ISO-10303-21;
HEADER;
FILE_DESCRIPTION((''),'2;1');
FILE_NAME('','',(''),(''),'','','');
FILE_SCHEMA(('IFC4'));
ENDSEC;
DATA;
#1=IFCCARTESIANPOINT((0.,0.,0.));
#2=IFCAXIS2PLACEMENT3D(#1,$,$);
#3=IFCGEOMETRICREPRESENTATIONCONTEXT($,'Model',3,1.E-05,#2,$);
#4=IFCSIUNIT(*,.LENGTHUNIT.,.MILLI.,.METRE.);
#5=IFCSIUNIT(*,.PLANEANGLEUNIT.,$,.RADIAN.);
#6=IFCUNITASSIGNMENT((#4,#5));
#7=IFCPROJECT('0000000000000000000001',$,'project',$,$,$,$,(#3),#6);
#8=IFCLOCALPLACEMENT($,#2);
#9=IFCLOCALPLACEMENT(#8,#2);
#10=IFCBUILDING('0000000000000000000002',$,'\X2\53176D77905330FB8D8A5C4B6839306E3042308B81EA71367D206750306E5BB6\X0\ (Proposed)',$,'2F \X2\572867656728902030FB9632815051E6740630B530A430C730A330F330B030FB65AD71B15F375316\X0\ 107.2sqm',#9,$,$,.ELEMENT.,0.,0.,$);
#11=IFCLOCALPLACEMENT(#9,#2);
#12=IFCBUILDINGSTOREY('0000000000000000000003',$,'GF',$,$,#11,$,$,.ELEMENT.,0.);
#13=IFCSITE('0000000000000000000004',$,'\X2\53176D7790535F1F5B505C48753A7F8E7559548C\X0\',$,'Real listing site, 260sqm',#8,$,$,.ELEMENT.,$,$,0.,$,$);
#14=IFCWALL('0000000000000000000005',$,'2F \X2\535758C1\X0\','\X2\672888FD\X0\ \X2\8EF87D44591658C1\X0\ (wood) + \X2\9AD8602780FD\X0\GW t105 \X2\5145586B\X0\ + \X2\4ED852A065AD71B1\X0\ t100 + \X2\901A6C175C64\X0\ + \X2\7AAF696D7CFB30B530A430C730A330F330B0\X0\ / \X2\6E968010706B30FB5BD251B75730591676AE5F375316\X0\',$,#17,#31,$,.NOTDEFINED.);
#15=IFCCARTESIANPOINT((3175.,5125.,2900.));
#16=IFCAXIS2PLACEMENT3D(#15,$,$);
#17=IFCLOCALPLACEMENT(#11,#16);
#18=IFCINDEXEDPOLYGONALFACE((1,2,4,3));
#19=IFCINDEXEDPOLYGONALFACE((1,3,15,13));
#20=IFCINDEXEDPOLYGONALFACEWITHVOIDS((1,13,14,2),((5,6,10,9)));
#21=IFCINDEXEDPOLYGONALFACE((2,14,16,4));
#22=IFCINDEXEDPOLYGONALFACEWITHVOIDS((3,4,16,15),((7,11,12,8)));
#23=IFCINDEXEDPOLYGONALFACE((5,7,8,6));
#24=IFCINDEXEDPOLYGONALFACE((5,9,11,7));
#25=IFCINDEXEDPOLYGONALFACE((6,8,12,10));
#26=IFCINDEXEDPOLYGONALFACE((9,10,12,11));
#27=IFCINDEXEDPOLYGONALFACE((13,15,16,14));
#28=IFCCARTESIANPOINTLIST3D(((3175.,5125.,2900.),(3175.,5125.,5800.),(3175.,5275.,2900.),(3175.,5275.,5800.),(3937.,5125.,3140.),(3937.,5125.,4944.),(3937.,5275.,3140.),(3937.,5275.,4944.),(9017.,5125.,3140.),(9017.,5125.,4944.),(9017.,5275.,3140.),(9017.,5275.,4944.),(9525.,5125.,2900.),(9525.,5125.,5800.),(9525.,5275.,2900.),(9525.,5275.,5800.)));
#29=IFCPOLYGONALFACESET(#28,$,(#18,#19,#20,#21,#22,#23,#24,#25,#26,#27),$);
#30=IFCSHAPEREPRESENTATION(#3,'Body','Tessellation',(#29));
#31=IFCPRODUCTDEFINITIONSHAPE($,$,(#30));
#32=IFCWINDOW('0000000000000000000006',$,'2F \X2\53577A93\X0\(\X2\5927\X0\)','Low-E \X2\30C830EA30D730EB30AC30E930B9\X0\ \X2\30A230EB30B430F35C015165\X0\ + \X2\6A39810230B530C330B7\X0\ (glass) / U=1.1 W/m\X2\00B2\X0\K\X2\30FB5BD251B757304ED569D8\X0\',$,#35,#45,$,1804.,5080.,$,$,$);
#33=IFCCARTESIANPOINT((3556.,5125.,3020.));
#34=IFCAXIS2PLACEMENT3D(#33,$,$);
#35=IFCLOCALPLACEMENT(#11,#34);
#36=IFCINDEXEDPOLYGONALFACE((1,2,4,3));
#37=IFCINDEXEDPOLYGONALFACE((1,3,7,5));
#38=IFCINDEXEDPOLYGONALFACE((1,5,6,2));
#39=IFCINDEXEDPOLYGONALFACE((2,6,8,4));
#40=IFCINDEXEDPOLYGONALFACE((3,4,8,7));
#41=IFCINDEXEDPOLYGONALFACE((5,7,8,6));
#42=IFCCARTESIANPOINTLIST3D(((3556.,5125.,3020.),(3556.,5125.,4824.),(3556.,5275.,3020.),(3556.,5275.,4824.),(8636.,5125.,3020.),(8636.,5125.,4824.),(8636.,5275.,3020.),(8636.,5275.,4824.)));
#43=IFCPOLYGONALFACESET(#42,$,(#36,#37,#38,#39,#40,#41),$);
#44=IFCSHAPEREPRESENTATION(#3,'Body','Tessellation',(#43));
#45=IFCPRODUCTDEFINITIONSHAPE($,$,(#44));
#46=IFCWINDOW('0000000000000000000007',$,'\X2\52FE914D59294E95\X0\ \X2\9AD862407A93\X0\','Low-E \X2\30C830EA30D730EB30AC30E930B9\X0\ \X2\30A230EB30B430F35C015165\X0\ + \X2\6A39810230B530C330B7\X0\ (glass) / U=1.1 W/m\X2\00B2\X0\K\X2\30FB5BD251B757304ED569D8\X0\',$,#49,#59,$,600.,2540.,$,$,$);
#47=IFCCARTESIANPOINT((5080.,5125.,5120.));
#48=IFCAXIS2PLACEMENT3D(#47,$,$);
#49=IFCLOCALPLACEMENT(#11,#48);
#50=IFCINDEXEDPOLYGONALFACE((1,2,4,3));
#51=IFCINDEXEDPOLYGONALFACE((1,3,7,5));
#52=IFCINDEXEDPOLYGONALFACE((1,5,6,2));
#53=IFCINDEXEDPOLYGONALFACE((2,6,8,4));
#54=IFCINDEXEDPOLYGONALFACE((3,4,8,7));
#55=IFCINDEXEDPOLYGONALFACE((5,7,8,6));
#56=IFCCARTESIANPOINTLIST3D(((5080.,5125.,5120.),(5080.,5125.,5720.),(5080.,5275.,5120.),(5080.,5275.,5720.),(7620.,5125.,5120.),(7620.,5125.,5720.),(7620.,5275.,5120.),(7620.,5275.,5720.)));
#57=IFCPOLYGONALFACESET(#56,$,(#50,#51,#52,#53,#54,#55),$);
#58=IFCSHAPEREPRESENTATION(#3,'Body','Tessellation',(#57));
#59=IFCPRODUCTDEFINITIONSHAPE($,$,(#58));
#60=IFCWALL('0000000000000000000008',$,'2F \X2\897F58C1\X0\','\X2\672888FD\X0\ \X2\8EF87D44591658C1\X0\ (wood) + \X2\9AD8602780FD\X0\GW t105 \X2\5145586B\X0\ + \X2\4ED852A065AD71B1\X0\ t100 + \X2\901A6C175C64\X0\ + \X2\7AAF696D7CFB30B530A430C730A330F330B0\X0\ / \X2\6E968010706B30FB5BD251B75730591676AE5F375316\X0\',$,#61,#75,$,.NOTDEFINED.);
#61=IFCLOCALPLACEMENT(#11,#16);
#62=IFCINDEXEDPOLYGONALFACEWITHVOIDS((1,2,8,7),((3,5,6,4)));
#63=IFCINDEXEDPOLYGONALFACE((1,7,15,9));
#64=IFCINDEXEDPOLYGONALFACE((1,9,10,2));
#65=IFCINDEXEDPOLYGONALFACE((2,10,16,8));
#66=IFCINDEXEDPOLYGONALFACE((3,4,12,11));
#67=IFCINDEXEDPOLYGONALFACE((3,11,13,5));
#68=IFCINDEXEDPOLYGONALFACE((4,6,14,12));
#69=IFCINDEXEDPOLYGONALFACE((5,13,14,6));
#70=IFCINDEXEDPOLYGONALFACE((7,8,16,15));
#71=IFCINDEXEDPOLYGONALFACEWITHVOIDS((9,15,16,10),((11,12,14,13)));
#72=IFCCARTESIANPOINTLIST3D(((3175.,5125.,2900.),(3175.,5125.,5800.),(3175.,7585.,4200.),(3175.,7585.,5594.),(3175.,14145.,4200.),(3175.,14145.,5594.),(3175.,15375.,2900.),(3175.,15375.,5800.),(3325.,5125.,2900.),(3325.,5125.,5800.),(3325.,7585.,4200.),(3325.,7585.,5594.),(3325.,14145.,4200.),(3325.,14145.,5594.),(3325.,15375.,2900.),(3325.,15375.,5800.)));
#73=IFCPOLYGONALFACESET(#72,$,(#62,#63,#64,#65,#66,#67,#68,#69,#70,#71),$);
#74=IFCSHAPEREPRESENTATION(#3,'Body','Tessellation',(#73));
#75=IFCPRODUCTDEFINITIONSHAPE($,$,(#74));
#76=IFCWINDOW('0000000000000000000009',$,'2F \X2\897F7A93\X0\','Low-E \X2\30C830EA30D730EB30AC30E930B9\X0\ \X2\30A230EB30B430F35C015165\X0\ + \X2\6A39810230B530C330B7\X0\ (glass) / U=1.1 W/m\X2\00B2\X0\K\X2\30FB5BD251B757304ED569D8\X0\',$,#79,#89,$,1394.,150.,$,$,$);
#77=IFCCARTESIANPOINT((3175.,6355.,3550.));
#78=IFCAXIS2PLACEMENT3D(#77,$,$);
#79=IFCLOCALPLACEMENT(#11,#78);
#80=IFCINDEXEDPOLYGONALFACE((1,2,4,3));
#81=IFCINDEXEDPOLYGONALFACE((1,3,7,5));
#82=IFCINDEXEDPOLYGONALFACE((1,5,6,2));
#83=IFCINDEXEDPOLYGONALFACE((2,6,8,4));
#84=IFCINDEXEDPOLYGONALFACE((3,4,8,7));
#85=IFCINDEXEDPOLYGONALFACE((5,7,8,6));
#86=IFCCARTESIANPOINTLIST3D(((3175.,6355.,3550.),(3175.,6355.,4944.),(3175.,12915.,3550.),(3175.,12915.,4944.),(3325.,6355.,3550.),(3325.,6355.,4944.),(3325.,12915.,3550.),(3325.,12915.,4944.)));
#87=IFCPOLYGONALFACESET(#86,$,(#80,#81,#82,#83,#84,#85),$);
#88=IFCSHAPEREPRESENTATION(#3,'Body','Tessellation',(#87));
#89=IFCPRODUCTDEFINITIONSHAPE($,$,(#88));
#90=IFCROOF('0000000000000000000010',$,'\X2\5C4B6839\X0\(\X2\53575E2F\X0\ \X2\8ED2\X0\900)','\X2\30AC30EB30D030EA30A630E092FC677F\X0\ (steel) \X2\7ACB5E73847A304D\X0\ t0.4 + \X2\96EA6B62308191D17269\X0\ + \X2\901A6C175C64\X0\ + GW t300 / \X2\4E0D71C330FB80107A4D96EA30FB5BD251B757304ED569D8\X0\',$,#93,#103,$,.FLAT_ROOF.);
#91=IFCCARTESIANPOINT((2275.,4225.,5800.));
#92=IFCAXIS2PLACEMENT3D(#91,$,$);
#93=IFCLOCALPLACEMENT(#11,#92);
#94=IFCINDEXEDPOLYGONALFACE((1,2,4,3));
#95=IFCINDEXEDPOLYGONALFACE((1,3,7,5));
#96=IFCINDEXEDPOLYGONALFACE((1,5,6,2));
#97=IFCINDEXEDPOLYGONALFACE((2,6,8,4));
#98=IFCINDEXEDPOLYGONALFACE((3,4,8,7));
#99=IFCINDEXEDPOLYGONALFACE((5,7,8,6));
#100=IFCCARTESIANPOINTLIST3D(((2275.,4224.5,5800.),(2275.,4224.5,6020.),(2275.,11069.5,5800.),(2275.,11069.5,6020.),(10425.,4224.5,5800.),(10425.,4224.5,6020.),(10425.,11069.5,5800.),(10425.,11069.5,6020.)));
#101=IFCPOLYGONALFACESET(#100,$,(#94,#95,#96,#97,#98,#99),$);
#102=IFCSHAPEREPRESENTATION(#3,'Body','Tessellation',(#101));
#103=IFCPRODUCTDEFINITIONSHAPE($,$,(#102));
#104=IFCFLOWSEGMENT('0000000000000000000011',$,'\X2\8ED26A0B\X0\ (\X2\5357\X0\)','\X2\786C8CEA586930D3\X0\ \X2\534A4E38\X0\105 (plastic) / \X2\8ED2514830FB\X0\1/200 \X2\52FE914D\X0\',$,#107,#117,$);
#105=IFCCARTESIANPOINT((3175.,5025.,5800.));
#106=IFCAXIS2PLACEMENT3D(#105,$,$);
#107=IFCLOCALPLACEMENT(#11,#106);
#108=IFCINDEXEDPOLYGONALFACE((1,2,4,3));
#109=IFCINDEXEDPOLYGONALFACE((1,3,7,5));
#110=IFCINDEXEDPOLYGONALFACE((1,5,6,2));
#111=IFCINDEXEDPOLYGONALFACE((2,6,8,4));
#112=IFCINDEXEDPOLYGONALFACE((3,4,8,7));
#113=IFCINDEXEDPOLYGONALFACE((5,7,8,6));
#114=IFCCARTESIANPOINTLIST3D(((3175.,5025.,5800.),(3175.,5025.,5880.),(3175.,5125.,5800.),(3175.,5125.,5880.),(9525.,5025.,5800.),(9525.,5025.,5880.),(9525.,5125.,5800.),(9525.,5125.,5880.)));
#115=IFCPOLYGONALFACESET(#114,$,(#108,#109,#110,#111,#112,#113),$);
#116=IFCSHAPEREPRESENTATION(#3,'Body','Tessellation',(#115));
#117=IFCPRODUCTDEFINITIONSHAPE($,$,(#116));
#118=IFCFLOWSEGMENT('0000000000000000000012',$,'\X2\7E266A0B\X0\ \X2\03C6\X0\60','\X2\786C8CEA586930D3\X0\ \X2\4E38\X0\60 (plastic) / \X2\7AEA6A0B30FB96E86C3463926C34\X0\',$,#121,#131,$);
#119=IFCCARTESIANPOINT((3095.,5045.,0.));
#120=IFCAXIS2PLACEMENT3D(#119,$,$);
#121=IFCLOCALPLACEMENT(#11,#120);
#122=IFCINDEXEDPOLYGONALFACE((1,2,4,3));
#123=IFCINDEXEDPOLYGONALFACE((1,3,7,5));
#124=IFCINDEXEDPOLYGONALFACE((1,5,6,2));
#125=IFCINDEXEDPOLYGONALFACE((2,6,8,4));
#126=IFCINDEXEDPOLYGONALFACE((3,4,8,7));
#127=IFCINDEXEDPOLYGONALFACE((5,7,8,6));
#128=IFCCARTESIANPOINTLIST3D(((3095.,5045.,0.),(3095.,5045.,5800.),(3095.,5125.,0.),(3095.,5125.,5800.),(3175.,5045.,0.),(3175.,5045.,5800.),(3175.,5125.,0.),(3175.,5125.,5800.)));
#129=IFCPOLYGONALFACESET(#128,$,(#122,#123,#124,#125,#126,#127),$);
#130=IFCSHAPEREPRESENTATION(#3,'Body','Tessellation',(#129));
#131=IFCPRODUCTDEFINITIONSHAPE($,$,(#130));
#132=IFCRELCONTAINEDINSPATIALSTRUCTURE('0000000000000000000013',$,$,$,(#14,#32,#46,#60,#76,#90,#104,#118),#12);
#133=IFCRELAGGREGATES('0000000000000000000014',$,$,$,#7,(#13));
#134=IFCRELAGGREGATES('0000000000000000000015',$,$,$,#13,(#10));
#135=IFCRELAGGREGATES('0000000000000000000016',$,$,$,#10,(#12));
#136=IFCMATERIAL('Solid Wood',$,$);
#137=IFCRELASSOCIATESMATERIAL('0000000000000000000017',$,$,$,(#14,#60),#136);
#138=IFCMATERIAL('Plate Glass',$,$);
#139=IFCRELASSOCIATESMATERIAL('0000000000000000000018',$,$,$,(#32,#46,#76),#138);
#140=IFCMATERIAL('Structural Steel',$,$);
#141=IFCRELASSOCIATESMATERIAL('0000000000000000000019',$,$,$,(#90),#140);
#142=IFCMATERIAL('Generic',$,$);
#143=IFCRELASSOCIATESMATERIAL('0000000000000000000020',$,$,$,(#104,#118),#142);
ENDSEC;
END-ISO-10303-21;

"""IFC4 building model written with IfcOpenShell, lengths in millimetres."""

from ifc_helpers import new_model, si_unit, frame, frame_2d, origin, place, context, project, spatial, rectangle, extrude, material, element, fill, save


model = new_model("IFC4")

# Units and contexts
model_context = context("Model", 3, precision=1e-05, world=origin())
ifc_project = project(units=[si_unit("LENGTHUNIT", "METRE", prefix="MILLI"), si_unit("PLANEANGLEUNIT", "RADIAN")], contexts=[model_context])

# Site, building, storey
site_placement = place(None, origin())
site = spatial("IfcSite", under=ifc_project, at=site_placement, Name="北海道弟子屈町美留和", ObjectType="Real listing site, 260sqm", CompositionType="ELEMENT", RefElevation=0.0)
building_placement = place(site_placement, origin())
building = spatial("IfcBuilding", under=site, at=building_placement, Name="北海道・越屋根のある自然素材の家 (Proposed)", ObjectType="2F 在来木造・防腐処理サイディング・断熱強化 107.2sqm", CompositionType="ELEMENT", ElevationOfRefHeight=0.0, ElevationOfTerrain=0.0)
storey_placement = place(building_placement, origin())
storey = spatial("IfcBuildingStorey", under=building, at=storey_placement, Name="GF", CompositionType="ELEMENT", Elevation=0.0)

# Shared definitions
ifc_material_1 = material(Name="Solid Wood")

# Shared definitions
ifc_material_2 = material(Name="Plate Glass")

# Wall, openings, windows
wall_1_placement = place(storey_placement, frame((3175.0, 5125.0, 2900.0)))
wall_1 = element("IfcWall", 1, at=wall_1_placement, inside=storey, material=ifc_material_1, Name="2F 南壁", Description="木製 軸組外壁 (wood) + 高性能GW t105 充填 + 付加断熱 t100 + 通気層 + 窯業系サイディング / 準耐火・寒冷地外皮強化", PredefinedType="NOTDEFINED", context=model_context, shape_type="SweptSolid", body=[
    extrude(rectangle(XDim=6350.0, YDim=150.0, at=frame_2d((3175.0, 75.0))), frame((3175.0, 5125.0, 2900.0)), (0.0, 0.0, 1.0), 2900.0),
])
opening_1_placement = place(storey_placement, frame((3556.0, 5125.0, 3020.0)))
opening_1 = element("IfcOpeningElement", 2, at=opening_1_placement, cuts=wall_1, PredefinedType="NOTDEFINED", context=model_context, shape_type="SweptSolid", body=[
    extrude(rectangle(XDim=5080.0, YDim=150.0, at=frame_2d((2540.0, 75.0))), frame((3556.0, 5125.0, 3020.0)), (0.0, 0.0, 1.0), 1804.0),
])
opening_2_placement = place(storey_placement, frame((5080.0, 5125.0, 5120.0)))
opening_2 = element("IfcOpeningElement", 3, at=opening_2_placement, cuts=wall_1, PredefinedType="NOTDEFINED", context=model_context, shape_type="SweptSolid", body=[
    extrude(rectangle(XDim=2540.0, YDim=150.0, at=frame_2d((1270.0, 75.0))), frame((5080.0, 5125.0, 5120.0)), (0.0, 0.0, 1.0), 600.0),
])
window_1_placement = place(storey_placement, frame((3556.0, 5125.0, 3020.0)))
window_1 = element("IfcWindow", 4, at=window_1_placement, inside=storey, material=ifc_material_2, Name="2F 南窓(大)", Description="Low-E トリプルガラス アルゴン封入 + 樹脂サッシ (glass) / U=1.1 W/m²K・寒冷地仕様", OverallHeight=1804.0, OverallWidth=5080.0, context=model_context, shape_type="SweptSolid", body=[
    extrude(rectangle(XDim=5080.0, YDim=150.0, at=frame_2d((2540.0, 75.0))), frame((3556.0, 5125.0, 3020.0)), (0.0, 0.0, 1.0), 1804.0),
])
fill(opening_1, window_1)
window_2_placement = place(storey_placement, frame((5080.0, 5125.0, 5120.0)))
window_2 = element("IfcWindow", 5, at=window_2_placement, inside=storey, material=ifc_material_2, Name="勾配天井 高所窓", Description="Low-E トリプルガラス アルゴン封入 + 樹脂サッシ (glass) / U=1.1 W/m²K・寒冷地仕様", OverallHeight=600.0, OverallWidth=2540.0, context=model_context, shape_type="SweptSolid", body=[
    extrude(rectangle(XDim=2540.0, YDim=150.0, at=frame_2d((1270.0, 75.0))), frame((5080.0, 5125.0, 5120.0)), (0.0, 0.0, 1.0), 600.0),
])
fill(opening_2, window_2)

# Wall, opening, window
wall_2_placement = place(storey_placement, frame((3175.0, 5125.0, 2900.0)))
wall_2 = element("IfcWall", 6, at=wall_2_placement, inside=storey, material=ifc_material_1, Name="2F 西壁", Description="木製 軸組外壁 (wood) + 高性能GW t105 充填 + 付加断熱 t100 + 通気層 + 窯業系サイディング / 準耐火・寒冷地外皮強化", PredefinedType="NOTDEFINED", context=model_context, shape_type="SweptSolid", body=[
    extrude(rectangle(XDim=150.0, YDim=10250.0, at=frame_2d((75.0, 5125.0))), frame((3175.0, 5125.0, 2900.0)), (0.0, 0.0, 1.0), 2900.0),
])
opening_3_placement = place(storey_placement, frame((3175.0, 6355.0, 3550.0)))
opening_3 = element("IfcOpeningElement", 7, at=opening_3_placement, cuts=wall_2, PredefinedType="NOTDEFINED", context=model_context, shape_type="SweptSolid", body=[
    extrude(rectangle(XDim=150.0, YDim=6560.0, at=frame_2d((75.0, 3280.0))), frame((3175.0, 6355.0, 3550.0)), (0.0, 0.0, 1.0), 1394.0),
])
window_3_placement = place(storey_placement, frame((3175.0, 6355.0, 3550.0)))
window_3 = element("IfcWindow", 8, at=window_3_placement, inside=storey, material=ifc_material_2, Name="2F 西窓", Description="Low-E トリプルガラス アルゴン封入 + 樹脂サッシ (glass) / U=1.1 W/m²K・寒冷地仕様", OverallHeight=1394.0, OverallWidth=150.0, context=model_context, shape_type="SweptSolid", body=[
    extrude(rectangle(XDim=150.0, YDim=6560.0, at=frame_2d((75.0, 3280.0))), frame((3175.0, 6355.0, 3550.0)), (0.0, 0.0, 1.0), 1394.0),
])
fill(opening_3, window_3)

# Roof
ifc_material_3 = material(Name="Structural Steel")
for number, where, name in (
    (9, (2275.0, 4225.0, 5800.0), "屋根(南帯 軒900)"),
):
    element("IfcRoof", number, at=place(storey_placement, frame(where)), inside=storey, material=ifc_material_3, Name=name, Description="ガルバリウム鋼板 (steel) 立平葺き t0.4 + 雪止め金物 + 通気層 + GW t300 / 不燃・耐積雪・寒冷地仕様", PredefinedType="FLAT_ROOF", context=model_context, shape_type="SweptSolid", body=[
        extrude(rectangle(XDim=8150.0, YDim=6845.0, at=frame_2d((4075.0, 3422.0))), frame((2275.0, 4225.0, 5800.0)), (0.0, 0.0, 1.0), 220.0),
    ])

# Flow segments
ifc_material_4 = material(Name="Generic")
flow_segment_1_placement = place(storey_placement, frame((3175.0, 5025.0, 5800.0)))
element("IfcFlowSegment", 10, at=flow_segment_1_placement, inside=storey, material=ifc_material_4, Name="軒樋 (南)", Description="硬質塩ビ 半丸105 (plastic) / 軒先・1/200 勾配", context=model_context, shape_type="SweptSolid", body=[
    extrude(rectangle(XDim=6350.0, YDim=100.0, at=frame_2d((3175.0, 50.0))), frame((3175.0, 5025.0, 5800.0)), (0.0, 0.0, 1.0), 80.0),
])
flow_segment_2_placement = place(storey_placement, frame((3095.0, 5045.0, 0.0)))
element("IfcFlowSegment", 11, at=flow_segment_2_placement, inside=storey, material=ifc_material_4, Name="縦樋 φ60", Description="硬質塩ビ 丸60 (plastic) / 竪樋・雨水排水", context=model_context, shape_type="SweptSolid", body=[
    extrude(rectangle(XDim=80.0, YDim=80.0, at=frame_2d((40.0, 40.0))), frame((3095.0, 5045.0, 0.0)), (0.0, 0.0, 1.0), 5800.0),
])

save(model, "model.ifc")
